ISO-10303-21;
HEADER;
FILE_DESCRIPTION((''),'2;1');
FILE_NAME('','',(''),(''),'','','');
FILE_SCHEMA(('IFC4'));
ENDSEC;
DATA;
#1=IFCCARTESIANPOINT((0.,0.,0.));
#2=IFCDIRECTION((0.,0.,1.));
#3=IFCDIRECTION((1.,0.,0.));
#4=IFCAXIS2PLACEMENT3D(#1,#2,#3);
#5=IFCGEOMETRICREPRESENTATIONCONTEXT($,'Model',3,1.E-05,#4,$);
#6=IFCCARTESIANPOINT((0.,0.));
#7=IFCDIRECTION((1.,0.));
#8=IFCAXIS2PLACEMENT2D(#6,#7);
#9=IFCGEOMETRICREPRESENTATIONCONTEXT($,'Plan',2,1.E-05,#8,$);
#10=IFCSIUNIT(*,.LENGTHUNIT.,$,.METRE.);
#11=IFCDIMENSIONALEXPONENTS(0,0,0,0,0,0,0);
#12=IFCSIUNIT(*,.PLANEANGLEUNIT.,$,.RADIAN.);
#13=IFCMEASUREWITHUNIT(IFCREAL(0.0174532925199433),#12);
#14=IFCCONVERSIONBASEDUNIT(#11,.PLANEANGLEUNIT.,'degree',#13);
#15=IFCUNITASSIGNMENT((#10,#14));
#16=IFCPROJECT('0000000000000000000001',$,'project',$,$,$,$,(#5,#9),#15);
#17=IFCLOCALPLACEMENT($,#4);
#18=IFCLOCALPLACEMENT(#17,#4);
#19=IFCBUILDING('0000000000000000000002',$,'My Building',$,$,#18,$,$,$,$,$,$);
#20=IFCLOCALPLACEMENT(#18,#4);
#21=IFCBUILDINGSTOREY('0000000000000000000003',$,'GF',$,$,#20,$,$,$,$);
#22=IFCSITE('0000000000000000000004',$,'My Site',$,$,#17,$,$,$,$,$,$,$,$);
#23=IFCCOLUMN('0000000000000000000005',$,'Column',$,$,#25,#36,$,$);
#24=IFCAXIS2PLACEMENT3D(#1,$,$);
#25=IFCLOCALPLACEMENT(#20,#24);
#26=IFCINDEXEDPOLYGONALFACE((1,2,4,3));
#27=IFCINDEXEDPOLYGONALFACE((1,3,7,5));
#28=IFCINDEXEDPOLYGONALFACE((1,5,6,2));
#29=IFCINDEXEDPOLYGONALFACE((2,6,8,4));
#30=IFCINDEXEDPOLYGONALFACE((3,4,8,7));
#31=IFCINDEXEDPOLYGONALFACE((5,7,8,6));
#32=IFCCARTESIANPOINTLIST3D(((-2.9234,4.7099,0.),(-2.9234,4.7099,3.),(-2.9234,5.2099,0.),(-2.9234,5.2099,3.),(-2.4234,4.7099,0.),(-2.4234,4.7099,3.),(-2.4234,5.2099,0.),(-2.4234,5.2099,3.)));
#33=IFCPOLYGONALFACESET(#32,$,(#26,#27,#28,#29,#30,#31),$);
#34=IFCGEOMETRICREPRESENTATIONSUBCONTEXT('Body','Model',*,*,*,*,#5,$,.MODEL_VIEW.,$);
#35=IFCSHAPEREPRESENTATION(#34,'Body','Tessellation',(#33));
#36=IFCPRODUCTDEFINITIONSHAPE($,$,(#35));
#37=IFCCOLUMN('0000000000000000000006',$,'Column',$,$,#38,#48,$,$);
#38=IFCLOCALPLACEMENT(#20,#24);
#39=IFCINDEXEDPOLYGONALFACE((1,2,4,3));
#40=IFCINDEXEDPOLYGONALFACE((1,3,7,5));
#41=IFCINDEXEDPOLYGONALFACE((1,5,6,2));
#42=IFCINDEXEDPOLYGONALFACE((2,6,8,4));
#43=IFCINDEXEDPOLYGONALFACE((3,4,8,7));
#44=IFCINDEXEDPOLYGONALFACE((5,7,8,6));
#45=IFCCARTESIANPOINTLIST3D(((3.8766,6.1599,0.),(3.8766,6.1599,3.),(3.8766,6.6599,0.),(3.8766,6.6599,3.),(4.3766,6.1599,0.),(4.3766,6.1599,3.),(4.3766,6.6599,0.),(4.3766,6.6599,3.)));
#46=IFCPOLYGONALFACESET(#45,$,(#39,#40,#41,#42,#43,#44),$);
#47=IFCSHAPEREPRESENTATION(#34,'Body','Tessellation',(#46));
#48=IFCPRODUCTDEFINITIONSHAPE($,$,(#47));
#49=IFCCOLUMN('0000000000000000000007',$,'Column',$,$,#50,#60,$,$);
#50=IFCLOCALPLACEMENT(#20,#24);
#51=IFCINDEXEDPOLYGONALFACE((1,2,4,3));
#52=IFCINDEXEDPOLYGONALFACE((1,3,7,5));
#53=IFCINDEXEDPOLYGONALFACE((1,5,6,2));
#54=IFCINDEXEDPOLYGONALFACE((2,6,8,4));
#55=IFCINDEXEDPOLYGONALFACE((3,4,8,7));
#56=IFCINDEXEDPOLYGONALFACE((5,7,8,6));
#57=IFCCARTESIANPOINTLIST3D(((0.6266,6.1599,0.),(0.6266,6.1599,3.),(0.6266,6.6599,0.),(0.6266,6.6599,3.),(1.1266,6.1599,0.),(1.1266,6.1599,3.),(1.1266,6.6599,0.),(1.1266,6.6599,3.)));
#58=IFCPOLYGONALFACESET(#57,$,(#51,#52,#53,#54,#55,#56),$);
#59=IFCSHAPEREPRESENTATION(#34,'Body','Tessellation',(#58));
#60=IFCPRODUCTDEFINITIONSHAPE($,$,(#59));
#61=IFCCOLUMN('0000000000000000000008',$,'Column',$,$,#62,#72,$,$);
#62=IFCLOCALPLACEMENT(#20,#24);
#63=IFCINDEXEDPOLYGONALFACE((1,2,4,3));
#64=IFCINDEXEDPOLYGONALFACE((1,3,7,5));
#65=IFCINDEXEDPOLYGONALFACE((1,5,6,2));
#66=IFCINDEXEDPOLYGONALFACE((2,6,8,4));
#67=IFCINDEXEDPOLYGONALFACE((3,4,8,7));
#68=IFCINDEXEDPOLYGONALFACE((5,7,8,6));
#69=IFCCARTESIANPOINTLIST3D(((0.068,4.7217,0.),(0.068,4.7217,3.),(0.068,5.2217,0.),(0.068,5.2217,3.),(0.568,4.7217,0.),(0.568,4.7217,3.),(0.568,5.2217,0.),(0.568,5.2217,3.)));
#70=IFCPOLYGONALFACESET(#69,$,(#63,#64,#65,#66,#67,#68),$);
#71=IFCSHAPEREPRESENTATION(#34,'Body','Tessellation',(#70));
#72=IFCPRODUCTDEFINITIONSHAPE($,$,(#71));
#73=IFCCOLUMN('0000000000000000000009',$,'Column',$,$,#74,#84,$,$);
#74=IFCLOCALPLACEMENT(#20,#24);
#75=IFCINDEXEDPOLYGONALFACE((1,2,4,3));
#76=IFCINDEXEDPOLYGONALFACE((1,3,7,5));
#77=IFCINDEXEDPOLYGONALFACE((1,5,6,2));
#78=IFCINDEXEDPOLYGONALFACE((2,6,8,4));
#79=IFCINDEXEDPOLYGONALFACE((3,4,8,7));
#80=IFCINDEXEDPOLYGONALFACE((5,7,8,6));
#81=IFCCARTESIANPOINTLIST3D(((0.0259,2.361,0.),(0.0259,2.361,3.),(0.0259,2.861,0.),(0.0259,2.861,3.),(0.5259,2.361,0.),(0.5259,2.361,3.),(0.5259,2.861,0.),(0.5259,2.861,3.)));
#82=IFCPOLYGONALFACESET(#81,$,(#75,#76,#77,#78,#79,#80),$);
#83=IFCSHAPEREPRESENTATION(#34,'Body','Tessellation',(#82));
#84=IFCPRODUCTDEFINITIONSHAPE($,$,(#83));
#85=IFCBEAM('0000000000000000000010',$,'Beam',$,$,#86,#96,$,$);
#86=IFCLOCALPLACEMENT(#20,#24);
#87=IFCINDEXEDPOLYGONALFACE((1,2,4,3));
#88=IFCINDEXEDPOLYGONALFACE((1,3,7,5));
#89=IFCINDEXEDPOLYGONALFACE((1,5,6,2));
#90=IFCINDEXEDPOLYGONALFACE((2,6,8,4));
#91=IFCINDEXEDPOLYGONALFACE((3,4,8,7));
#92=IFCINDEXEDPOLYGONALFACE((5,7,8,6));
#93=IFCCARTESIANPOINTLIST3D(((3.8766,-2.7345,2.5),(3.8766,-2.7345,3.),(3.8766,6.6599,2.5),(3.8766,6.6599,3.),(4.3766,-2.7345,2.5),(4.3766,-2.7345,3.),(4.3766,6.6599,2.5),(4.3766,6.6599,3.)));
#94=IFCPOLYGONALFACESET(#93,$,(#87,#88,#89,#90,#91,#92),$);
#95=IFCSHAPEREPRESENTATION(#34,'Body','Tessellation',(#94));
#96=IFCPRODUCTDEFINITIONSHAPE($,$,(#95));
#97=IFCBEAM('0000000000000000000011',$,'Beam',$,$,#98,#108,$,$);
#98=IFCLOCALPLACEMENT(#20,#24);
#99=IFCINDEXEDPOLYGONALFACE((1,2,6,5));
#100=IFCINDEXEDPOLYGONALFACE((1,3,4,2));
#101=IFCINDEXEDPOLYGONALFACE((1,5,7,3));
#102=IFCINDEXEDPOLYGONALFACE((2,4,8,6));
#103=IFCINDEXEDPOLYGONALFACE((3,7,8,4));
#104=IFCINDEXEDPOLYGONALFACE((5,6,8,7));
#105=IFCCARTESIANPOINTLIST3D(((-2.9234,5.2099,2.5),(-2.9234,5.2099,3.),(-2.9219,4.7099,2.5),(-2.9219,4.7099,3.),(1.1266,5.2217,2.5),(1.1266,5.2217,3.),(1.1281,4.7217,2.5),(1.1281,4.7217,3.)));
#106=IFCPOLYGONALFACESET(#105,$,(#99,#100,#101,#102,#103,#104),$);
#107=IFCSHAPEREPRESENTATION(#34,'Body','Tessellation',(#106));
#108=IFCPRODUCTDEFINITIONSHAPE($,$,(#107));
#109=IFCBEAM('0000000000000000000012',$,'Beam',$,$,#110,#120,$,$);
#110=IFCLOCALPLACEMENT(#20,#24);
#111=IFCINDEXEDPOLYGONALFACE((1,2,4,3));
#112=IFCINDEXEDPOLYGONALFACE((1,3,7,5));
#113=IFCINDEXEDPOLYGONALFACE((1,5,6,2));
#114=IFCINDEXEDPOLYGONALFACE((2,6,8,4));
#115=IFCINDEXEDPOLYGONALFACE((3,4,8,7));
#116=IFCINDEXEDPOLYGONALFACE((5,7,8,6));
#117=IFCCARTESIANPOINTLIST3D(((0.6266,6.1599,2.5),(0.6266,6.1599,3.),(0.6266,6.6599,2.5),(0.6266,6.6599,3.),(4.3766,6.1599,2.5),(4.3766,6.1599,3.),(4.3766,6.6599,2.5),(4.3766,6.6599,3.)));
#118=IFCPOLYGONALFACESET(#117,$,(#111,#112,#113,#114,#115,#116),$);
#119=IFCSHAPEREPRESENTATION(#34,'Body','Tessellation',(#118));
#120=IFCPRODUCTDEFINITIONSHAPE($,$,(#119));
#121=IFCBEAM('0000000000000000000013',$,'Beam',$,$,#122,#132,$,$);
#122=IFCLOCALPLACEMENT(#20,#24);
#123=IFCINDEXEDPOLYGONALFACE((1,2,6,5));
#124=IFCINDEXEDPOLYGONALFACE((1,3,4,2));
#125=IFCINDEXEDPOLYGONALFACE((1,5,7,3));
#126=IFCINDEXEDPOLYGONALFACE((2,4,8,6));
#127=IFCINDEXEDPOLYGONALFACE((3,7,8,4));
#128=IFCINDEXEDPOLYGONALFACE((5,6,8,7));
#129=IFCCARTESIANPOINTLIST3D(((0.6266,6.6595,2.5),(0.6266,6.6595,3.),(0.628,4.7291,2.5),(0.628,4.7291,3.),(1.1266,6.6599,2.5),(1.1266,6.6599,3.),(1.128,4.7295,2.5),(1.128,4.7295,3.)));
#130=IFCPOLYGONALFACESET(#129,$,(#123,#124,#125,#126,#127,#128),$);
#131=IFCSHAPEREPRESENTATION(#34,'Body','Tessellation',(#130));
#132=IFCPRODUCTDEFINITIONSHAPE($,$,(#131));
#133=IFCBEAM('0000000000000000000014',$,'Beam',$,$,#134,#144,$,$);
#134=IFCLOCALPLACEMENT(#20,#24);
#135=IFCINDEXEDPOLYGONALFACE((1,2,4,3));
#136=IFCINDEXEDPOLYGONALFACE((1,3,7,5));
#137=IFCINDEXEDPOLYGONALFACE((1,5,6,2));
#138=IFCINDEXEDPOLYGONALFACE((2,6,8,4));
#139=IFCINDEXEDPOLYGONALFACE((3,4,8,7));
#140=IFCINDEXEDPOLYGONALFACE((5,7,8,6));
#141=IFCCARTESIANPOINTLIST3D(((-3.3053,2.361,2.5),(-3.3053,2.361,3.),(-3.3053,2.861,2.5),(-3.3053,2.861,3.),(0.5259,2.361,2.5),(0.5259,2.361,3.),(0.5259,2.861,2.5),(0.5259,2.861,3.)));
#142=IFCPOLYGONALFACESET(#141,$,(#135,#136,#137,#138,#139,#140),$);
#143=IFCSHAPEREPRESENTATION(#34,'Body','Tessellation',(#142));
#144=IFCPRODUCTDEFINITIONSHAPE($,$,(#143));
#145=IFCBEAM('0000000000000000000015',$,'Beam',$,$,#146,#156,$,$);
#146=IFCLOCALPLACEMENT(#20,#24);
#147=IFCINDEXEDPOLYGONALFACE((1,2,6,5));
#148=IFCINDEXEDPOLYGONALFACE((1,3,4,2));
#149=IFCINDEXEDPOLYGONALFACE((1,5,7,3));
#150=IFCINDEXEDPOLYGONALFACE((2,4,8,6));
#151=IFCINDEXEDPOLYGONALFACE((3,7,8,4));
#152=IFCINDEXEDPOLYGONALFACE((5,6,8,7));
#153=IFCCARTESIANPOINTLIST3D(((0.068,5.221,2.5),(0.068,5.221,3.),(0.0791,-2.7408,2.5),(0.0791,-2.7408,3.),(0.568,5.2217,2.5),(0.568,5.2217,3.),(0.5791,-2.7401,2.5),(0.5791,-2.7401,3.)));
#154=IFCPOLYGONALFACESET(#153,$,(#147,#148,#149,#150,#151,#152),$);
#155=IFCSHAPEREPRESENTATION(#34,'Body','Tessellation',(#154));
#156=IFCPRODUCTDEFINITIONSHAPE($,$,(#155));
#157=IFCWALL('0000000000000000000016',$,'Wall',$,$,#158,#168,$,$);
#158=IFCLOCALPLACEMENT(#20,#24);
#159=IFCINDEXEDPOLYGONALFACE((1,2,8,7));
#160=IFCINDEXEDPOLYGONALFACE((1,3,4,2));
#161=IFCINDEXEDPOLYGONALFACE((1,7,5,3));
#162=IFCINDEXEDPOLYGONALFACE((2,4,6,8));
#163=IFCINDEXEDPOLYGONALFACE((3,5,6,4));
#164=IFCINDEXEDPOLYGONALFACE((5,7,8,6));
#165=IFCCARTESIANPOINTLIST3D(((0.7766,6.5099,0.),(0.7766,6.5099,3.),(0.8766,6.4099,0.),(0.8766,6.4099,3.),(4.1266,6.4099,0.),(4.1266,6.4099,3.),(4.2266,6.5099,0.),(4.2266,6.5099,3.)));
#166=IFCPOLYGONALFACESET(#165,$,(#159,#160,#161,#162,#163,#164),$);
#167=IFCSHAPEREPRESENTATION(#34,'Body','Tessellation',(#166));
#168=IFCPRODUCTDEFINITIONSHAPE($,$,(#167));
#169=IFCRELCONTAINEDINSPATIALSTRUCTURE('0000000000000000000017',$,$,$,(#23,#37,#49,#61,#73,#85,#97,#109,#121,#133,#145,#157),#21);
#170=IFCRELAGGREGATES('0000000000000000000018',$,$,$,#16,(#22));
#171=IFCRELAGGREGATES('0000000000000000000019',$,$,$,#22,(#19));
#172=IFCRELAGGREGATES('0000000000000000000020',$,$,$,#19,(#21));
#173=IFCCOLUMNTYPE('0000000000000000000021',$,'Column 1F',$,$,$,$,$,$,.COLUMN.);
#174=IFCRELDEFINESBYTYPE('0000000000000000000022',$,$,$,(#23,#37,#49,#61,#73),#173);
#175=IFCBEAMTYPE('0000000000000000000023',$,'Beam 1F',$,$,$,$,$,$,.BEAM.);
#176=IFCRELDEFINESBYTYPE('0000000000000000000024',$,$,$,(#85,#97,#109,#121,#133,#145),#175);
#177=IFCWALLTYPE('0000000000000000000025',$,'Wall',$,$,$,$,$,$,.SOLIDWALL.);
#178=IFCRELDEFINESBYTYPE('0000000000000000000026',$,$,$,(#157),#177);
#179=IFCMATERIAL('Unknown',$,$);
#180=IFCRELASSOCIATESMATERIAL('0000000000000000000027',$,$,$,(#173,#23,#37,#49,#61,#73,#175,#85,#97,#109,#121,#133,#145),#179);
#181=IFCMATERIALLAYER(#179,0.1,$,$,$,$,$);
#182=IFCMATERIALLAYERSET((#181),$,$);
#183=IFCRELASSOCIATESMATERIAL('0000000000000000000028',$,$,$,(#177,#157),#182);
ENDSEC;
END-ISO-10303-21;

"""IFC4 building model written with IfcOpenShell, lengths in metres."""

from ifc_helpers import new_model, entity, si_unit, converted_unit, frame, origin_with_axes, origin_2d_with_axis, place, context, subcontext, project, spatial, line, indexed_curve, rectangle, outline, extrude, material, layer, layer_set, layer_usage, material_profile, profile_set, profile_usage, type_object, element, save


model = new_model("IFC4")

# Units and contexts
model_context = context("Model", 3, precision=1e-05, world=origin_with_axes())
plan_context = context("Plan", 2, precision=1e-05, world=origin_2d_with_axis())
body_context_1 = subcontext(model_context, "Body", "Model", "MODEL_VIEW")
ifc_project = project(units=[si_unit("LENGTHUNIT", "METRE"), converted_unit("PLANEANGLEUNIT", "degree", entity("IfcReal", 0.0174532925199433), si_unit("PLANEANGLEUNIT", "RADIAN"), dimensions=[0, 0, 0, 0, 0, 0, 0])], contexts=[model_context, plan_context])

# Site, building, storey
site_placement = place(None, origin_with_axes())
site = spatial("IfcSite", under=ifc_project, at=site_placement, Name="My Site")
building_placement = place(site_placement, origin_with_axes())
building = spatial("IfcBuilding", under=site, at=building_placement, Name="My Building")
storey_placement = place(building_placement, origin_with_axes())
storey = spatial("IfcBuildingStorey", under=building, at=storey_placement, Name="GF")

# Columns
ifc_material = material(Name="Unknown")
ifc_material_profile_1 = material_profile(ifc_material, rectangle(XDim=0.5, YDim=0.5))
ifc_profile_set_1 = profile_set([ifc_material_profile_1])
ifc_profile_usage_1 = profile_usage(ifc_profile_set_1, cardinal=5)
column_type = type_object("IfcColumnType", Name="Column 1F", PredefinedType="COLUMN", material=ifc_profile_set_1)
column_1_placement = place(storey_placement, frame((-2.6734, 4.9599, 0.0), z_axis=(0.0, 0.0, 1.0), x_axis=(1.0, 0.0, 0.0)))
element("IfcColumn", 1, at=column_1_placement, inside=storey, type_object=column_type, material=ifc_profile_usage_1, Name="Column", context=body_context_1, shape_type="SweptSolid", body=[
    extrude(rectangle(XDim=0.5, YDim=0.5), origin_with_axes(), (0.0, 0.0, 1.0), 3.0),
])
ifc_profile_usage_2 = profile_usage(ifc_profile_set_1, cardinal=5)
column_2_placement = place(storey_placement, frame((4.1266, 6.4099, 0.0), z_axis=(0.0, 0.0, 1.0), x_axis=(1.0, 0.0, 0.0)))
element("IfcColumn", 2, at=column_2_placement, inside=storey, type_object=column_type, material=ifc_profile_usage_2, Name="Column", context=body_context_1, shape_type="SweptSolid", body=[
    extrude(rectangle(XDim=0.5, YDim=0.5), origin_with_axes(), (0.0, 0.0, 1.0), 3.0),
])
ifc_profile_usage_3 = profile_usage(ifc_profile_set_1, cardinal=5)
column_3_placement = place(storey_placement, frame((0.8766, 6.4099, 0.0), z_axis=(0.0, 0.0, 1.0), x_axis=(1.0, 0.0, 0.0)))
element("IfcColumn", 3, at=column_3_placement, inside=storey, type_object=column_type, material=ifc_profile_usage_3, Name="Column", context=body_context_1, shape_type="SweptSolid", body=[
    extrude(rectangle(XDim=0.5, YDim=0.5), origin_with_axes(), (0.0, 0.0, 1.0), 3.0),
])
ifc_profile_usage_4 = profile_usage(ifc_profile_set_1, cardinal=5)
column_4_placement = place(storey_placement, frame((0.318, 4.9717, 0.0), z_axis=(0.0, 0.0, 1.0), x_axis=(1.0, 0.0, 0.0)))
element("IfcColumn", 4, at=column_4_placement, inside=storey, type_object=column_type, material=ifc_profile_usage_4, Name="Column", context=body_context_1, shape_type="SweptSolid", body=[
    extrude(rectangle(XDim=0.5, YDim=0.5), origin_with_axes(), (0.0, 0.0, 1.0), 3.0),
])
ifc_profile_usage_5 = profile_usage(ifc_profile_set_1, cardinal=5)
column_5_placement = place(storey_placement, frame((0.2759, 2.611, 0.0), z_axis=(0.0, 0.0, 1.0), x_axis=(1.0, 0.0, 0.0)))
element("IfcColumn", 5, at=column_5_placement, inside=storey, type_object=column_type, material=ifc_profile_usage_5, Name="Column", context=body_context_1, shape_type="SweptSolid", body=[
    extrude(rectangle(XDim=0.5, YDim=0.5), origin_with_axes(), (0.0, 0.0, 1.0), 3.0),
])

# Beams
ifc_material_profile_2 = material_profile(ifc_material, rectangle(XDim=0.5, YDim=0.5))
ifc_profile_set_2 = profile_set([ifc_material_profile_2])
ifc_profile_usage_6 = profile_usage(ifc_profile_set_2, cardinal=7)
beam_type = type_object("IfcBeamType", Name="Beam 1F", PredefinedType="BEAM", material=ifc_profile_set_2)
beam_1_placement = place(storey_placement, frame((4.3766, 6.6599, 3.0), z_axis=(0.0, -1.0, 0.0), x_axis=(1.0, 0.0, 0.0)))
element("IfcBeam", 6, at=beam_1_placement, inside=storey, type_object=beam_type, material=ifc_profile_usage_6, Name="Beam", context=body_context_1, shape_type="SweptSolid", body=[
    extrude(rectangle(XDim=0.5, YDim=0.5), frame((-0.25, -0.25, 0.0), z_axis=(0.0, 0.0, 1.0), x_axis=(1.0, 0.0, 0.0)), (0.0, 0.0, 1.0), 9.3944),
])
ifc_profile_usage_7 = profile_usage(ifc_profile_set_2, cardinal=7)
beam_2_placement = place(storey_placement, frame((-2.9234, 5.2099, 3.0), z_axis=(0.999996, 0.002921, 0.0), x_axis=(-0.002921, 0.999996, 0.0)))
element("IfcBeam", 7, at=beam_2_placement, inside=storey, type_object=beam_type, material=ifc_profile_usage_7, Name="Beam", context=body_context_1, shape_type="SweptSolid", body=[
    extrude(rectangle(XDim=0.5, YDim=0.5), frame((-0.25, -0.25, 0.0), z_axis=(0.0, 0.0, 1.0), x_axis=(1.0, 0.0, 0.0)), (0.0, 0.0, 1.0), 4.05),
])
ifc_profile_usage_8 = profile_usage(ifc_profile_set_2, cardinal=7)
beam_3_placement = place(storey_placement, frame((0.6266, 6.6599, 3.0), z_axis=(1.0, 0.0, 0.0), x_axis=(0.0, 1.0, 0.0)))
element("IfcBeam", 8, at=beam_3_placement, inside=storey, type_object=beam_type, material=ifc_profile_usage_8, Name="Beam", context=body_context_1, shape_type="SweptSolid", body=[
    extrude(rectangle(XDim=0.5, YDim=0.5), frame((-0.25, -0.25, 0.0), z_axis=(0.0, 0.0, 1.0), x_axis=(1.0, 0.0, 0.0)), (0.0, 0.0, 1.0), 3.75),
])
ifc_profile_usage_9 = profile_usage(ifc_profile_set_2, cardinal=7)
beam_4_placement = place(storey_placement, frame((1.1266, 6.6599, 3.0), z_axis=(0.000745, -1.0, 0.0), x_axis=(1.0, 0.000745, 0.0)))
element("IfcBeam", 9, at=beam_4_placement, inside=storey, type_object=beam_type, material=ifc_profile_usage_9, Name="Beam", context=body_context_1, shape_type="SweptSolid", body=[
    extrude(rectangle(XDim=0.5, YDim=0.5), frame((-0.25, -0.25, 0.0), z_axis=(0.0, 0.0, 1.0), x_axis=(1.0, 0.0, 0.0)), (0.0, 0.0, 1.0), 1.9304),
])
ifc_profile_usage_10 = profile_usage(ifc_profile_set_2, cardinal=1)
beam_5_placement = place(storey_placement, frame((-3.3053, 2.861, 2.5), z_axis=(1.0, 0.0, 0.0), x_axis=(0.0, 1.0, 0.0)))
element("IfcBeam", 10, at=beam_5_placement, inside=storey, type_object=beam_type, material=ifc_profile_usage_10, Name="Beam", context=body_context_1, shape_type="SweptSolid", body=[
    extrude(rectangle(XDim=0.5, YDim=0.5), frame((-0.25, 0.25, 0.0), z_axis=(0.0, 0.0, 1.0), x_axis=(1.0, 0.0, 0.0)), (0.0, 0.0, 1.0), 3.8312),
])
ifc_profile_usage_11 = profile_usage(ifc_profile_set_2, cardinal=7)
beam_6_placement = place(storey_placement, frame((0.568, 5.2217, 3.0), z_axis=(0.001385, -0.999999, 0.0), x_axis=(0.999999, 0.001385, 0.0)))
element("IfcBeam", 11, at=beam_6_placement, inside=storey, type_object=beam_type, material=ifc_profile_usage_11, Name="Beam", context=body_context_1, shape_type="SweptSolid", body=[
    extrude(rectangle(XDim=0.5, YDim=0.5), frame((-0.25, -0.25, 0.0), z_axis=(0.0, 0.0, 1.0), x_axis=(1.0, 0.0, 0.0)), (0.0, 0.0, 1.0), 7.9618),
])

# Wall
ifc_layer = layer(ifc_material, 0.1)
ifc_layer_set = layer_set([ifc_layer])
ifc_layer_usage_1 = layer_usage(ifc_layer_set, "AXIS2", "POSITIVE", 0.0)
wall_type = type_object("IfcWallType", Name="Wall", PredefinedType="SOLIDWALL", material=ifc_layer_set)
wall_1_placement = place(storey_placement, frame((4.2266, 6.5099, 0.0), z_axis=(0.0, 0.0, 1.0), x_axis=(-1.0, 0.0, 0.0)))
element("IfcWall", 12, at=wall_1_placement, inside=storey, type_object=wall_type, material=ifc_layer_usage_1, Name="Wall", context=body_context_1, shape_type="SweptSolid", body=[
    extrude(outline(indexed_curve([(0.0, 0.0), (0.1, 0.1), (3.35, 0.1), (3.45, 0.0)], segments=[line(1, 2, 3, 4, 1)])), origin_with_axes(), (0.0, 0.0, 1.0), 3.0),
])

save(model, "model.ifc")
